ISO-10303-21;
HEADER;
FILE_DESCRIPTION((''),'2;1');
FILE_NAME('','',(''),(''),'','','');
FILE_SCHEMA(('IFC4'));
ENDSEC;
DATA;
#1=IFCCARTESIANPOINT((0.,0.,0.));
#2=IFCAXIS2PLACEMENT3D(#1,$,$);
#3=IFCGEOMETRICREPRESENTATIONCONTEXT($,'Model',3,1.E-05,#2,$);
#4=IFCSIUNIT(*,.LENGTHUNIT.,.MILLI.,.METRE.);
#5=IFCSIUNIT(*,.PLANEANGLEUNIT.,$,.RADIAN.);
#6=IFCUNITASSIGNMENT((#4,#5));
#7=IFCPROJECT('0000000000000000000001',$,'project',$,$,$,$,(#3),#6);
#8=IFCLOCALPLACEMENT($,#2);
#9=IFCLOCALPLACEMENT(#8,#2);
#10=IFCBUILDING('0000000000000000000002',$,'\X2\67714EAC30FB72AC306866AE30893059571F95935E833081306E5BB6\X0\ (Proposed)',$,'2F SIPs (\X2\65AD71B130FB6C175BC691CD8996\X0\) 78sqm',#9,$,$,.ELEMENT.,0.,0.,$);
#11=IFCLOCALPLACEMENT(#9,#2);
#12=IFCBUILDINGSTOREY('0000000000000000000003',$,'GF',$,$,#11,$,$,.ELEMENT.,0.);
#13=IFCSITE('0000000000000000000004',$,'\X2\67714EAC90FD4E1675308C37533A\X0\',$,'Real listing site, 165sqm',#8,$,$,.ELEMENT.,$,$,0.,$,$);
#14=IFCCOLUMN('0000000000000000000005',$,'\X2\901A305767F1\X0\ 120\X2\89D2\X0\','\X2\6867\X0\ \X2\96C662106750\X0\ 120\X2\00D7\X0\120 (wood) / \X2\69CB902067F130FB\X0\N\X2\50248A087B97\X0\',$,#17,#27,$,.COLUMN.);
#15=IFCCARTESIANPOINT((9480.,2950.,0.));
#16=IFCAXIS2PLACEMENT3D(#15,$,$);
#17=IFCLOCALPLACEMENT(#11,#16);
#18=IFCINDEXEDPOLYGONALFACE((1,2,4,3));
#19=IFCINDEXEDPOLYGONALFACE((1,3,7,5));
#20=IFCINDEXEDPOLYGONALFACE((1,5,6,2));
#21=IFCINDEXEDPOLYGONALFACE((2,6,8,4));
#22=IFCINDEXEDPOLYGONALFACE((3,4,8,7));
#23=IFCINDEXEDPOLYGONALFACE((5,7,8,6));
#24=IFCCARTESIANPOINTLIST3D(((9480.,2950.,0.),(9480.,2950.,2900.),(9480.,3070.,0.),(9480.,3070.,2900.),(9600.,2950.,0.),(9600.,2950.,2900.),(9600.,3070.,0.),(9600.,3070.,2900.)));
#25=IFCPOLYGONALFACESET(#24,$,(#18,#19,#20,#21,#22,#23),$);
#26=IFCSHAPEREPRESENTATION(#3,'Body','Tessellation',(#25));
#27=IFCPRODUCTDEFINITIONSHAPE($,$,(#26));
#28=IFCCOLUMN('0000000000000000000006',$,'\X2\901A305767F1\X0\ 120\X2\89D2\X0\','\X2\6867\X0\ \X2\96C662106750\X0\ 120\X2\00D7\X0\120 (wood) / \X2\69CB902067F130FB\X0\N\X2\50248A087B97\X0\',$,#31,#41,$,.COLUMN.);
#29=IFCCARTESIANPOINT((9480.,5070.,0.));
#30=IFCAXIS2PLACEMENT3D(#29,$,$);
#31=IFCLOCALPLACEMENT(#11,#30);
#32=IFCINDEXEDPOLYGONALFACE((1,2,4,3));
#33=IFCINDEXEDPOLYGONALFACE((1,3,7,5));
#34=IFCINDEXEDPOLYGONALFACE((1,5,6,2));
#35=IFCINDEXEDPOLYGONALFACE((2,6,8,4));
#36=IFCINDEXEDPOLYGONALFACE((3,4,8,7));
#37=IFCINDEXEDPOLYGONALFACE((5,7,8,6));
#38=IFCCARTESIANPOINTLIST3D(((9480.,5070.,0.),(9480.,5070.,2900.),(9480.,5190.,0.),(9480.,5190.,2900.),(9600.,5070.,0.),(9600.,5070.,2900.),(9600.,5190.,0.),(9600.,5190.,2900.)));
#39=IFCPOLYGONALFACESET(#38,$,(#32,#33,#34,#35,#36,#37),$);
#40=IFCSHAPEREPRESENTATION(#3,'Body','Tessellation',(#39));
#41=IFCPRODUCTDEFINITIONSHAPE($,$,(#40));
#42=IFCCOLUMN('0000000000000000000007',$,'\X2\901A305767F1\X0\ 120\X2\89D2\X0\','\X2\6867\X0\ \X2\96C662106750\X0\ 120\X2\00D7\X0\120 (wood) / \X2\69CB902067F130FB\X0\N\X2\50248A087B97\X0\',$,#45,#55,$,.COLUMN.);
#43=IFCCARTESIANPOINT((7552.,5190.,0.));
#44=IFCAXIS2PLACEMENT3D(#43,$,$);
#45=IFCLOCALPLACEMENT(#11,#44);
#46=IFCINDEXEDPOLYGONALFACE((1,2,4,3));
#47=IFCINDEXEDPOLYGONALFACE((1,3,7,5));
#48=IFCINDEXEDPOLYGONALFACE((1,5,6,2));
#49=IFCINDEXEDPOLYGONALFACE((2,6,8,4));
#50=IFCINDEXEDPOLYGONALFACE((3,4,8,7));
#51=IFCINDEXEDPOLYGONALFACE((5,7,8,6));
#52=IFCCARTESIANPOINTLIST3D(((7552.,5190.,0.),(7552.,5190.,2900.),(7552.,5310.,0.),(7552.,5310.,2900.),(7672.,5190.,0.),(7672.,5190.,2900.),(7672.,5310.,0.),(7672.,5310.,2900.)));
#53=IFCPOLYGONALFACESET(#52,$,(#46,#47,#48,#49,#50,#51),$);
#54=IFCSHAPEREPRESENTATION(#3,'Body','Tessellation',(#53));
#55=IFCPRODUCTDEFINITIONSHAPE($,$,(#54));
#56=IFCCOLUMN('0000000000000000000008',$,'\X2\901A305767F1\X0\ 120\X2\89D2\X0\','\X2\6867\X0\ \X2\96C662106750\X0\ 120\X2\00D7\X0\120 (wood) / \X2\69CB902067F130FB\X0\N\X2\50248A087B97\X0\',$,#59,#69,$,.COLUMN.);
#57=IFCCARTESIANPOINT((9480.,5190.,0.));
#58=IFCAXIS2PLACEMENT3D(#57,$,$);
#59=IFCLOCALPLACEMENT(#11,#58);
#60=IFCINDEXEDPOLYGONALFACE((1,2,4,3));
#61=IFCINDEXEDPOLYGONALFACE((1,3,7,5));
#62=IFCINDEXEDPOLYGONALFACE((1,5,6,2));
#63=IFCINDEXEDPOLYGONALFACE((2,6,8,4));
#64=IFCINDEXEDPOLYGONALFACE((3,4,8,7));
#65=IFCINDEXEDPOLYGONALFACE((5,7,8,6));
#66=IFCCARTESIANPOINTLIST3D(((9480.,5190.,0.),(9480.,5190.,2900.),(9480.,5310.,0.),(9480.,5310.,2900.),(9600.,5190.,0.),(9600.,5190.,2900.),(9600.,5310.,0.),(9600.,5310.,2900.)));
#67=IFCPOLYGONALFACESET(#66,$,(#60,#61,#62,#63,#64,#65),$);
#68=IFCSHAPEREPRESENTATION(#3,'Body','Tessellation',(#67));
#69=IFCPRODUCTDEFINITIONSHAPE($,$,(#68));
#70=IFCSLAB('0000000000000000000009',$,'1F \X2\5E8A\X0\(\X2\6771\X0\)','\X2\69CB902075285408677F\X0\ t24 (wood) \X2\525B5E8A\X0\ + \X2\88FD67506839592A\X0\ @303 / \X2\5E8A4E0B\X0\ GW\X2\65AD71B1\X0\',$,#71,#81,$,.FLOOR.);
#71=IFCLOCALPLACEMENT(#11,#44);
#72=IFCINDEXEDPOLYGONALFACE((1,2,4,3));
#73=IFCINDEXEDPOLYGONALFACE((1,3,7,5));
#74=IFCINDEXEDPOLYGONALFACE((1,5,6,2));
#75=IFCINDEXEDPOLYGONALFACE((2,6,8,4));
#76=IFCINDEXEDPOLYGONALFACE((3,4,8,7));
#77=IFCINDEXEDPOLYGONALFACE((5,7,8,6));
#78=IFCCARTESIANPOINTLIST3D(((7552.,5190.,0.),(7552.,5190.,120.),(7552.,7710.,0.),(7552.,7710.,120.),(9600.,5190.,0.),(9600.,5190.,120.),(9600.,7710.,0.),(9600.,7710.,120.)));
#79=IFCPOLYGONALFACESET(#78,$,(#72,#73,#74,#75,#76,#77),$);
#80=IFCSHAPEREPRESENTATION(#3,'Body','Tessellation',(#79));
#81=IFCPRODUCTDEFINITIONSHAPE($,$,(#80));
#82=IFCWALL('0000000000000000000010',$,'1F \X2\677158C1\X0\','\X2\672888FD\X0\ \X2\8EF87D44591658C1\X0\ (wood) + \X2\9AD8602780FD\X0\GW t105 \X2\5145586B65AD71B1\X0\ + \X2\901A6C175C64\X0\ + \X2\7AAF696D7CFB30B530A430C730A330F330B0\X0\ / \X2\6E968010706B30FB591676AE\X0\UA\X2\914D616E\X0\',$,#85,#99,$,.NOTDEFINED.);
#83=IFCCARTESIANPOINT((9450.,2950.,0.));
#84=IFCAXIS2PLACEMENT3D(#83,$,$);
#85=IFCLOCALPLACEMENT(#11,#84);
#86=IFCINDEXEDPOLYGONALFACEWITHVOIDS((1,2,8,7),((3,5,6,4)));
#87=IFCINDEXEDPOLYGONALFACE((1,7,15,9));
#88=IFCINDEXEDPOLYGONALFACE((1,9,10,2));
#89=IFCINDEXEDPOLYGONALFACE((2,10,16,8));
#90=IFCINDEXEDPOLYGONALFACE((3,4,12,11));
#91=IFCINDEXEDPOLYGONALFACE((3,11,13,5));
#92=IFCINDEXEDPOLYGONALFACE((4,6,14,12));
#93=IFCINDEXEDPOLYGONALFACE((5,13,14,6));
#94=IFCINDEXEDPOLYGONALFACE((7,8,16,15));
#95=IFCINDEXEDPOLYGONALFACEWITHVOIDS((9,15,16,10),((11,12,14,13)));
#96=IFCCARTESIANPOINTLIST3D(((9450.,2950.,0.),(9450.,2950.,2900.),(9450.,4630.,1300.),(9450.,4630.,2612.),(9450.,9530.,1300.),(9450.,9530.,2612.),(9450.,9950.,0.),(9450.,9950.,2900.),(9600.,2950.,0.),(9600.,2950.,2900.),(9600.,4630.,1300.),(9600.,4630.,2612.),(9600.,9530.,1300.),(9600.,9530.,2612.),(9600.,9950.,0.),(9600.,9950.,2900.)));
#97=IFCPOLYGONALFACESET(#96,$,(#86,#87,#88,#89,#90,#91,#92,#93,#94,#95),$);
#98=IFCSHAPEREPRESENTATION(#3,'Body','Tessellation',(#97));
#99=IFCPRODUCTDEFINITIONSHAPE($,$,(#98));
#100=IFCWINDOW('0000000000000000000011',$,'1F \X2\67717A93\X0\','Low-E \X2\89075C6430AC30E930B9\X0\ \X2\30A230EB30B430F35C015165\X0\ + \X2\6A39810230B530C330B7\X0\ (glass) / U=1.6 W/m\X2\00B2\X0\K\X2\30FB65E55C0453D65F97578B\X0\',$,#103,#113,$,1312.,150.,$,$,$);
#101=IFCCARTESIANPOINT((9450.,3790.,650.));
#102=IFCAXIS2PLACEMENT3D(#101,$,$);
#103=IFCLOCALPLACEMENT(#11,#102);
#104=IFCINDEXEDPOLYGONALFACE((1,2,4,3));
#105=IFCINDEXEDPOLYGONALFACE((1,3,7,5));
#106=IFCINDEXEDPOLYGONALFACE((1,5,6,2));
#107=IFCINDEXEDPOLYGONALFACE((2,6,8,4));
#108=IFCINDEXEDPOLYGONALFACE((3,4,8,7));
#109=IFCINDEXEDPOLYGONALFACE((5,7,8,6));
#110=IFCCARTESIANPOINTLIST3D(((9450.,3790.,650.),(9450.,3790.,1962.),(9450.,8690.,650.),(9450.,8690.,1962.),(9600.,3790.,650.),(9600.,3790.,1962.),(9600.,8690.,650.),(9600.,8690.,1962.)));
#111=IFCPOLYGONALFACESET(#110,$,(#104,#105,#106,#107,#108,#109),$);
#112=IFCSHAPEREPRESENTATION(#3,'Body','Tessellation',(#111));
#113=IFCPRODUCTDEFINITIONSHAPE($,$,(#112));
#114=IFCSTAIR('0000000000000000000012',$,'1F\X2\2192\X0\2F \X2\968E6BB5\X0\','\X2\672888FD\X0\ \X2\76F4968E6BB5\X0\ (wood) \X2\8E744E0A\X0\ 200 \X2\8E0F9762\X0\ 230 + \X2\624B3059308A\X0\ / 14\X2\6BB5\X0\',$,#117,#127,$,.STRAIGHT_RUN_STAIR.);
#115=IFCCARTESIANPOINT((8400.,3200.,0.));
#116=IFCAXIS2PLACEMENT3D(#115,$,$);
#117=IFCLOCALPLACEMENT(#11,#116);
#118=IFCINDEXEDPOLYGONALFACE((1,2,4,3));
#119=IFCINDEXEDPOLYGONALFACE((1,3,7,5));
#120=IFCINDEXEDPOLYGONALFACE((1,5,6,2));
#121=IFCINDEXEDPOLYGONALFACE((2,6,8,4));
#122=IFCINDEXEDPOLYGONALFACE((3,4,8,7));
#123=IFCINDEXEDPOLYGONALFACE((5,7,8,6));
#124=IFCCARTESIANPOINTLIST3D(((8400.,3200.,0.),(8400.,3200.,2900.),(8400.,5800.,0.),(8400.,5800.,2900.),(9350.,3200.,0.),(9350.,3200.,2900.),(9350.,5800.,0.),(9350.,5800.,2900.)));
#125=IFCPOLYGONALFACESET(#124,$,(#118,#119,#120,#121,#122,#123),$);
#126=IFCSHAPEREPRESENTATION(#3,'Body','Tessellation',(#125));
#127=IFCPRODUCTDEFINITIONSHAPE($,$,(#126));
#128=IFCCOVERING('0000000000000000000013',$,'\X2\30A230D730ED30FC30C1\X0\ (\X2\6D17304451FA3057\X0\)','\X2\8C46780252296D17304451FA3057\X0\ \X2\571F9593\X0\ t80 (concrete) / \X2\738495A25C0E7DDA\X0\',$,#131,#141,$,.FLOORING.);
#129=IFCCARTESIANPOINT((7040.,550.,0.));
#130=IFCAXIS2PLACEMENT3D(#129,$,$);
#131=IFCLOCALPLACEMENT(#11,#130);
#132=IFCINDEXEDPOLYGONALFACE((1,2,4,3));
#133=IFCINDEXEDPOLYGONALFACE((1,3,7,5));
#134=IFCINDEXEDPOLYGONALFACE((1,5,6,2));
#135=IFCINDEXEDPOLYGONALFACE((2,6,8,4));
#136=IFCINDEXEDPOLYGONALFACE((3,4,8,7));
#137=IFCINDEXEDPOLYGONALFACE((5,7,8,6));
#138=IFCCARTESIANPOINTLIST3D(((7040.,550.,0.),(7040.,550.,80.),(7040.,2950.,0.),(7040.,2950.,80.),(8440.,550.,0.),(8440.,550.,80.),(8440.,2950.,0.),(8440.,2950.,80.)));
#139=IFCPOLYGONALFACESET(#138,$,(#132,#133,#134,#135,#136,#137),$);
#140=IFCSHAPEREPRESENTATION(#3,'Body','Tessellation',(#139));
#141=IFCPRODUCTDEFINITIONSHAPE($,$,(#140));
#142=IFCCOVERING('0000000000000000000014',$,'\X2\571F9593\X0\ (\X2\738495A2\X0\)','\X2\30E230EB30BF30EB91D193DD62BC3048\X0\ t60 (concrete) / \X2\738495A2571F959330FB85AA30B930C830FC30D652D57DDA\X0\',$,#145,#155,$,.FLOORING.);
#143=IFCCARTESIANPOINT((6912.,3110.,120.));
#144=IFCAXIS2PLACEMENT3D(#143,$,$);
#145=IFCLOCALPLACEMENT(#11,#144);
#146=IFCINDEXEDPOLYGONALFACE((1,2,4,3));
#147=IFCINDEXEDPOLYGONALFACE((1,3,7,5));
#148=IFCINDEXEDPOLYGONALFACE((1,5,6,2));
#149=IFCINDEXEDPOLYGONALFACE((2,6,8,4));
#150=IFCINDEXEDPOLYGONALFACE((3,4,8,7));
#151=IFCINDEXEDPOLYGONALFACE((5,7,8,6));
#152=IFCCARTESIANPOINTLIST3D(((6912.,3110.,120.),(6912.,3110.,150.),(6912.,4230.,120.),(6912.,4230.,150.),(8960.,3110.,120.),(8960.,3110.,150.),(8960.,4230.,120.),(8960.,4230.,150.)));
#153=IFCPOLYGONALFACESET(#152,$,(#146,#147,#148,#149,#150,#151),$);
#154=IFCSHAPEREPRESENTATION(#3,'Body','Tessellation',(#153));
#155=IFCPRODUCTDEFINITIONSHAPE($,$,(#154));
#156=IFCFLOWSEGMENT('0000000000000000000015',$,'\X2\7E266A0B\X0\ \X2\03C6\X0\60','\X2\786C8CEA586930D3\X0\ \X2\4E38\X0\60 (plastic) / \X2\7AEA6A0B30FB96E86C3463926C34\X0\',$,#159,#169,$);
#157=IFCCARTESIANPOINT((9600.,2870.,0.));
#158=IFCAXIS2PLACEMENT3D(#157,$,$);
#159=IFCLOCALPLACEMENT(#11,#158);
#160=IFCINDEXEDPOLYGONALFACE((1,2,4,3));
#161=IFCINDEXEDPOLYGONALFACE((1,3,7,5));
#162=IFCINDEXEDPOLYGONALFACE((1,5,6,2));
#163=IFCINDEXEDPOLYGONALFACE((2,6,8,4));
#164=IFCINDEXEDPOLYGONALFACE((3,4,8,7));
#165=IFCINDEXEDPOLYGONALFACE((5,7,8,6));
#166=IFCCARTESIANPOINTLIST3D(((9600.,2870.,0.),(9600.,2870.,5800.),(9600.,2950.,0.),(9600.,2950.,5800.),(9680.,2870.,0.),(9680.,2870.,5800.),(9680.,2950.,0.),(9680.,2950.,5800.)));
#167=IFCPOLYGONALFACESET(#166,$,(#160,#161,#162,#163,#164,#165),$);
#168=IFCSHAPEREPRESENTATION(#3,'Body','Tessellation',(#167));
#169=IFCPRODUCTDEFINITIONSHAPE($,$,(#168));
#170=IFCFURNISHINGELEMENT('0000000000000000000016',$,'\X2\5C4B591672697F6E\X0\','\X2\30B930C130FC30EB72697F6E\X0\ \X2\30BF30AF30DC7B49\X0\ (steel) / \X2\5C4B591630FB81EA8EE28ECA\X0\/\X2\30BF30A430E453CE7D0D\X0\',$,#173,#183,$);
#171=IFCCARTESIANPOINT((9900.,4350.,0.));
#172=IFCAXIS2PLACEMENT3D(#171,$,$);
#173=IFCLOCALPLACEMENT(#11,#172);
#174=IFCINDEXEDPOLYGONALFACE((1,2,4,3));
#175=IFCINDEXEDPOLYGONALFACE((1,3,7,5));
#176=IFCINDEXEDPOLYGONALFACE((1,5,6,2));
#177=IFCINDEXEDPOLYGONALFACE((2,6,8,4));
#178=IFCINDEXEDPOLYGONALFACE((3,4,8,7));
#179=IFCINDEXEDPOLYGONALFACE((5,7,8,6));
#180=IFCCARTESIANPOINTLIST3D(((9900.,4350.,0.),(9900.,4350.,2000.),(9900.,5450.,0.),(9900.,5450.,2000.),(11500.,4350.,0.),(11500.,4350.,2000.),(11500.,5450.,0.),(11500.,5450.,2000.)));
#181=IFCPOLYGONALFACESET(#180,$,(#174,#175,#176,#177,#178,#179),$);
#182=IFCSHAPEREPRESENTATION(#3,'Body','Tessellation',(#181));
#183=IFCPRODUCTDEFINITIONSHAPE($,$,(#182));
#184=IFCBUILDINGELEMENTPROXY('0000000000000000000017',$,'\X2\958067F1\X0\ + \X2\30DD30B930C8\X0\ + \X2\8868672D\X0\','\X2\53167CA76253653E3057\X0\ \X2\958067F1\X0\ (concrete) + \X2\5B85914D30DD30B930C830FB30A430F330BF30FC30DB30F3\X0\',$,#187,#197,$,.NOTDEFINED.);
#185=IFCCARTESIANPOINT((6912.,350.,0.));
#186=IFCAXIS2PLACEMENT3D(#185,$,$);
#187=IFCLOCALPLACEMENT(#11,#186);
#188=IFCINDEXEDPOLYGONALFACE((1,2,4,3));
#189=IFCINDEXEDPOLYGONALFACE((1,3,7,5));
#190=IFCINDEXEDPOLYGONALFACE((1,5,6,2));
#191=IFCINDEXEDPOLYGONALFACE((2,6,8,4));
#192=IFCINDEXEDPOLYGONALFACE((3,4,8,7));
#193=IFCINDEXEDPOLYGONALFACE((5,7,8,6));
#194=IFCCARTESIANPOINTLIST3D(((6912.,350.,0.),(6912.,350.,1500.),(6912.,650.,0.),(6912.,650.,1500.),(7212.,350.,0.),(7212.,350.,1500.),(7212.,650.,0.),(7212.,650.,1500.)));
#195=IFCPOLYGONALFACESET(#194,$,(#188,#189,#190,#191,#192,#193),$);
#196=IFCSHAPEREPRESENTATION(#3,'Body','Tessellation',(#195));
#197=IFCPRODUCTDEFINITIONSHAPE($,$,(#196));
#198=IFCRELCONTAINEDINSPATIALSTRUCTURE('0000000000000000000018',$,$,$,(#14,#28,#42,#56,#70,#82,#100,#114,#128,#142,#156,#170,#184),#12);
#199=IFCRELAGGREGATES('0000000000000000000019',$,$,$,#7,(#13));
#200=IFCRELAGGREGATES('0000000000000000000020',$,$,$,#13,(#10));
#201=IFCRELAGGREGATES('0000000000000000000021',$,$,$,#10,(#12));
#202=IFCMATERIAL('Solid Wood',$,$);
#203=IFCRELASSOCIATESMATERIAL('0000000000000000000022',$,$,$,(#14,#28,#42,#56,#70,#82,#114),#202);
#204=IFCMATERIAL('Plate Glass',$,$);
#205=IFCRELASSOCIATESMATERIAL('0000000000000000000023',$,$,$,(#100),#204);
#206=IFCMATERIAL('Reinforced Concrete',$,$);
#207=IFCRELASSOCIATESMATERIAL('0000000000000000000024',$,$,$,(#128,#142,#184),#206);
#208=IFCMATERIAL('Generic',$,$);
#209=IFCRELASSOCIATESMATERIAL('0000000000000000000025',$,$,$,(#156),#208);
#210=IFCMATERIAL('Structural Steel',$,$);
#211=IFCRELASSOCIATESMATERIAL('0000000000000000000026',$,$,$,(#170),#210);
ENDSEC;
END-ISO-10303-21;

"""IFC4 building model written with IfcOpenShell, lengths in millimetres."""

from ifc_helpers import new_model, si_unit, frame, frame_2d, origin, place, context, project, spatial, rectangle, extrude, material, element, fill, save


model = new_model("IFC4")

# Units and contexts
model_context = context("Model", 3, precision=1e-05, world=origin())
ifc_project = project(units=[si_unit("LENGTHUNIT", "METRE", prefix="MILLI"), si_unit("PLANEANGLEUNIT", "RADIAN")], contexts=[model_context])

# Site, building, storey
site_placement = place(None, origin())
site = spatial("IfcSite", under=ifc_project, at=site_placement, Name="東京都世田谷区", ObjectType="Real listing site, 165sqm", CompositionType="ELEMENT", RefElevation=0.0)
building_placement = place(site_placement, origin())
building = spatial("IfcBuilding", under=site, at=building_placement, Name="東京・犬と暮らす土間広めの家 (Proposed)", ObjectType="2F SIPs (断熱・気密重視) 78sqm", CompositionType="ELEMENT", ElevationOfRefHeight=0.0, ElevationOfTerrain=0.0)
storey_placement = place(building_placement, origin())
storey = spatial("IfcBuildingStorey", under=building, at=storey_placement, Name="GF", CompositionType="ELEMENT", Elevation=0.0)

# Columns
ifc_material_1 = material(Name="Solid Wood")
column_1_placement = place(storey_placement, frame((9480.0, 2950.0, 0.0)))
element("IfcColumn", 1, at=column_1_placement, inside=storey, material=ifc_material_1, Name="通し柱 120角", Description="桧 集成材 120×120 (wood) / 構造柱・N値計算", PredefinedType="COLUMN", context=model_context, shape_type="SweptSolid", body=[
    extrude(rectangle(XDim=120.0, YDim=120.0, at=frame_2d((60.0, 60.0))), frame((9480.0, 2950.0, 0.0)), (0.0, 0.0, 1.0), 2900.0),
])
column_2_placement = place(storey_placement, frame((9480.0, 5070.0, 0.0)))
element("IfcColumn", 2, at=column_2_placement, inside=storey, material=ifc_material_1, Name="通し柱 120角", Description="桧 集成材 120×120 (wood) / 構造柱・N値計算", PredefinedType="COLUMN", context=model_context, shape_type="SweptSolid", body=[
    extrude(rectangle(XDim=120.0, YDim=120.0, at=frame_2d((60.0, 60.0))), frame((9480.0, 5070.0, 0.0)), (0.0, 0.0, 1.0), 2900.0),
])
column_3_placement = place(storey_placement, frame((7552.0, 5190.0, 0.0)))
element("IfcColumn", 3, at=column_3_placement, inside=storey, material=ifc_material_1, Name="通し柱 120角", Description="桧 集成材 120×120 (wood) / 構造柱・N値計算", PredefinedType="COLUMN", context=model_context, shape_type="SweptSolid", body=[
    extrude(rectangle(XDim=120.0, YDim=120.0, at=frame_2d((60.0, 60.0))), frame((7552.0, 5190.0, 0.0)), (0.0, 0.0, 1.0), 2900.0),
])
column_4_placement = place(storey_placement, frame((9480.0, 5190.0, 0.0)))
element("IfcColumn", 4, at=column_4_placement, inside=storey, material=ifc_material_1, Name="通し柱 120角", Description="桧 集成材 120×120 (wood) / 構造柱・N値計算", PredefinedType="COLUMN", context=model_context, shape_type="SweptSolid", body=[
    extrude(rectangle(XDim=120.0, YDim=120.0, at=frame_2d((60.0, 60.0))), frame((9480.0, 5190.0, 0.0)), (0.0, 0.0, 1.0), 2900.0),
])

# Slab
slab_placement = place(storey_placement, frame((7552.0, 5190.0, 0.0)))
element("IfcSlab", 5, at=slab_placement, inside=storey, material=ifc_material_1, Name="1F 床(東)", Description="構造用合板 t24 (wood) 剛床 + 製材根太 @303 / 床下 GW断熱", PredefinedType="FLOOR", context=model_context, shape_type="SweptSolid", body=[
    extrude(rectangle(XDim=2048.0, YDim=2520.0, at=frame_2d((1024.0, 1260.0))), frame((7552.0, 5190.0, 0.0)), (0.0, 0.0, 1.0), 120.0),
])

# Wall, opening, window
wall_1_placement = place(storey_placement, frame((9450.0, 2950.0, 0.0)))
wall_1 = element("IfcWall", 6, at=wall_1_placement, inside=storey, material=ifc_material_1, Name="1F 東壁", Description="木製 軸組外壁 (wood) + 高性能GW t105 充填断熱 + 通気層 + 窯業系サイディング / 準耐火・外皮UA配慮", PredefinedType="NOTDEFINED", context=model_context, shape_type="SweptSolid", body=[
    extrude(rectangle(XDim=150.0, YDim=7000.0, at=frame_2d((75.0, 3500.0))), frame((9450.0, 2950.0, 0.0)), (0.0, 0.0, 1.0), 2900.0),
])
opening_placement = place(storey_placement, frame((9450.0, 3790.0, 650.0)))
opening = element("IfcOpeningElement", 7, at=opening_placement, cuts=wall_1, PredefinedType="NOTDEFINED", context=model_context, shape_type="SweptSolid", body=[
    extrude(rectangle(XDim=150.0, YDim=4900.0, at=frame_2d((75.0, 2450.0))), frame((9450.0, 3790.0, 650.0)), (0.0, 0.0, 1.0), 1312.0),
])
ifc_material_2 = material(Name="Plate Glass")
window_placement = place(storey_placement, frame((9450.0, 3790.0, 650.0)))
window = element("IfcWindow", 8, at=window_placement, inside=storey, material=ifc_material_2, Name="1F 東窓", Description="Low-E 複層ガラス アルゴン封入 + 樹脂サッシ (glass) / U=1.6 W/m²K・日射取得型", OverallHeight=1312.0, OverallWidth=150.0, context=model_context, shape_type="SweptSolid", body=[
    extrude(rectangle(XDim=150.0, YDim=4900.0, at=frame_2d((75.0, 2450.0))), frame((9450.0, 3790.0, 650.0)), (0.0, 0.0, 1.0), 1312.0),
])
fill(opening, window)

# Stair
stair_placement = place(storey_placement, frame((8400.0, 3200.0, 0.0)))
element("IfcStair", 9, at=stair_placement, inside=storey, material=ifc_material_1, Name="1F→2F 階段", Description="木製 直階段 (wood) 蹴上 200 踏面 230 + 手すり / 14段", PredefinedType="STRAIGHT_RUN_STAIR", context=model_context, shape_type="SweptSolid", body=[
    extrude(rectangle(XDim=950.0, YDim=2600.0, at=frame_2d((475.0, 1300.0))), frame((8400.0, 3200.0, 0.0)), (0.0, 0.0, 1.0), 2900.0),
])

# Coverings
ifc_material_3 = material(Name="Reinforced Concrete")
covering_1_placement = place(storey_placement, frame((7040.0, 550.0, 0.0)))
element("IfcCovering", 10, at=covering_1_placement, inside=storey, material=ifc_material_3, Name="アプローチ (洗い出し)", Description="豆砂利洗い出し 土間 t80 (concrete) / 玄関導線", PredefinedType="FLOORING", context=model_context, shape_type="SweptSolid", body=[
    extrude(rectangle(XDim=1400.0, YDim=2400.0, at=frame_2d((700.0, 1200.0))), frame((7040.0, 550.0, 0.0)), (0.0, 0.0, 1.0), 80.0),
])
covering_2_placement = place(storey_placement, frame((6912.0, 3110.0, 120.0)))
element("IfcCovering", 11, at=covering_2_placement, inside=storey, material=ifc_material_3, Name="土間 (玄関)", Description="モルタル金鏝押え t60 (concrete) / 玄関土間・薪ストーブ動線", PredefinedType="FLOORING", context=model_context, shape_type="SweptSolid", body=[
    extrude(rectangle(XDim=2048.0, YDim=1120.0, at=frame_2d((1024.0, 560.0))), frame((6912.0, 3110.0, 120.0)), (0.0, 0.0, 1.0), 30.0),
])

# Flow segment
ifc_material_4 = material(Name="Generic")
flow_segment_placement = place(storey_placement, frame((9600.0, 2870.0, 0.0)))
element("IfcFlowSegment", 12, at=flow_segment_placement, inside=storey, material=ifc_material_4, Name="縦樋 φ60", Description="硬質塩ビ 丸60 (plastic) / 竪樋・雨水排水", context=model_context, shape_type="SweptSolid", body=[
    extrude(rectangle(XDim=80.0, YDim=80.0, at=frame_2d((40.0, 40.0))), frame((9600.0, 2870.0, 0.0)), (0.0, 0.0, 1.0), 5800.0),
])

# Furnishing element
ifc_material_5 = material(Name="Structural Steel")
furnishing_placement = place(storey_placement, frame((9900.0, 4350.0, 0.0)))
element("IfcFurnishingElement", 13, at=furnishing_placement, inside=storey, material=ifc_material_5, Name="屋外物置", Description="スチール物置 タクボ等 (steel) / 屋外・自転車/タイヤ収納", context=model_context, shape_type="SweptSolid", body=[
    extrude(rectangle(XDim=1600.0, YDim=1100.0, at=frame_2d((800.0, 550.0))), frame((9900.0, 4350.0, 0.0)), (0.0, 0.0, 1.0), 2000.0),
])

# Building element proxy
proxy_placement = place(storey_placement, frame((6912.0, 350.0, 0.0)))
element("IfcBuildingElementProxy", 14, at=proxy_placement, inside=storey, material=ifc_material_3, Name="門柱 + ポスト + 表札", Description="化粧打放し 門柱 (concrete) + 宅配ポスト・インターホン", PredefinedType="NOTDEFINED", context=model_context, shape_type="SweptSolid", body=[
    extrude(rectangle(XDim=300.0, YDim=300.0, at=frame_2d((150.0, 150.0))), frame((6912.0, 350.0, 0.0)), (0.0, 0.0, 1.0), 1500.0),
])

save(model, "model.ifc")
